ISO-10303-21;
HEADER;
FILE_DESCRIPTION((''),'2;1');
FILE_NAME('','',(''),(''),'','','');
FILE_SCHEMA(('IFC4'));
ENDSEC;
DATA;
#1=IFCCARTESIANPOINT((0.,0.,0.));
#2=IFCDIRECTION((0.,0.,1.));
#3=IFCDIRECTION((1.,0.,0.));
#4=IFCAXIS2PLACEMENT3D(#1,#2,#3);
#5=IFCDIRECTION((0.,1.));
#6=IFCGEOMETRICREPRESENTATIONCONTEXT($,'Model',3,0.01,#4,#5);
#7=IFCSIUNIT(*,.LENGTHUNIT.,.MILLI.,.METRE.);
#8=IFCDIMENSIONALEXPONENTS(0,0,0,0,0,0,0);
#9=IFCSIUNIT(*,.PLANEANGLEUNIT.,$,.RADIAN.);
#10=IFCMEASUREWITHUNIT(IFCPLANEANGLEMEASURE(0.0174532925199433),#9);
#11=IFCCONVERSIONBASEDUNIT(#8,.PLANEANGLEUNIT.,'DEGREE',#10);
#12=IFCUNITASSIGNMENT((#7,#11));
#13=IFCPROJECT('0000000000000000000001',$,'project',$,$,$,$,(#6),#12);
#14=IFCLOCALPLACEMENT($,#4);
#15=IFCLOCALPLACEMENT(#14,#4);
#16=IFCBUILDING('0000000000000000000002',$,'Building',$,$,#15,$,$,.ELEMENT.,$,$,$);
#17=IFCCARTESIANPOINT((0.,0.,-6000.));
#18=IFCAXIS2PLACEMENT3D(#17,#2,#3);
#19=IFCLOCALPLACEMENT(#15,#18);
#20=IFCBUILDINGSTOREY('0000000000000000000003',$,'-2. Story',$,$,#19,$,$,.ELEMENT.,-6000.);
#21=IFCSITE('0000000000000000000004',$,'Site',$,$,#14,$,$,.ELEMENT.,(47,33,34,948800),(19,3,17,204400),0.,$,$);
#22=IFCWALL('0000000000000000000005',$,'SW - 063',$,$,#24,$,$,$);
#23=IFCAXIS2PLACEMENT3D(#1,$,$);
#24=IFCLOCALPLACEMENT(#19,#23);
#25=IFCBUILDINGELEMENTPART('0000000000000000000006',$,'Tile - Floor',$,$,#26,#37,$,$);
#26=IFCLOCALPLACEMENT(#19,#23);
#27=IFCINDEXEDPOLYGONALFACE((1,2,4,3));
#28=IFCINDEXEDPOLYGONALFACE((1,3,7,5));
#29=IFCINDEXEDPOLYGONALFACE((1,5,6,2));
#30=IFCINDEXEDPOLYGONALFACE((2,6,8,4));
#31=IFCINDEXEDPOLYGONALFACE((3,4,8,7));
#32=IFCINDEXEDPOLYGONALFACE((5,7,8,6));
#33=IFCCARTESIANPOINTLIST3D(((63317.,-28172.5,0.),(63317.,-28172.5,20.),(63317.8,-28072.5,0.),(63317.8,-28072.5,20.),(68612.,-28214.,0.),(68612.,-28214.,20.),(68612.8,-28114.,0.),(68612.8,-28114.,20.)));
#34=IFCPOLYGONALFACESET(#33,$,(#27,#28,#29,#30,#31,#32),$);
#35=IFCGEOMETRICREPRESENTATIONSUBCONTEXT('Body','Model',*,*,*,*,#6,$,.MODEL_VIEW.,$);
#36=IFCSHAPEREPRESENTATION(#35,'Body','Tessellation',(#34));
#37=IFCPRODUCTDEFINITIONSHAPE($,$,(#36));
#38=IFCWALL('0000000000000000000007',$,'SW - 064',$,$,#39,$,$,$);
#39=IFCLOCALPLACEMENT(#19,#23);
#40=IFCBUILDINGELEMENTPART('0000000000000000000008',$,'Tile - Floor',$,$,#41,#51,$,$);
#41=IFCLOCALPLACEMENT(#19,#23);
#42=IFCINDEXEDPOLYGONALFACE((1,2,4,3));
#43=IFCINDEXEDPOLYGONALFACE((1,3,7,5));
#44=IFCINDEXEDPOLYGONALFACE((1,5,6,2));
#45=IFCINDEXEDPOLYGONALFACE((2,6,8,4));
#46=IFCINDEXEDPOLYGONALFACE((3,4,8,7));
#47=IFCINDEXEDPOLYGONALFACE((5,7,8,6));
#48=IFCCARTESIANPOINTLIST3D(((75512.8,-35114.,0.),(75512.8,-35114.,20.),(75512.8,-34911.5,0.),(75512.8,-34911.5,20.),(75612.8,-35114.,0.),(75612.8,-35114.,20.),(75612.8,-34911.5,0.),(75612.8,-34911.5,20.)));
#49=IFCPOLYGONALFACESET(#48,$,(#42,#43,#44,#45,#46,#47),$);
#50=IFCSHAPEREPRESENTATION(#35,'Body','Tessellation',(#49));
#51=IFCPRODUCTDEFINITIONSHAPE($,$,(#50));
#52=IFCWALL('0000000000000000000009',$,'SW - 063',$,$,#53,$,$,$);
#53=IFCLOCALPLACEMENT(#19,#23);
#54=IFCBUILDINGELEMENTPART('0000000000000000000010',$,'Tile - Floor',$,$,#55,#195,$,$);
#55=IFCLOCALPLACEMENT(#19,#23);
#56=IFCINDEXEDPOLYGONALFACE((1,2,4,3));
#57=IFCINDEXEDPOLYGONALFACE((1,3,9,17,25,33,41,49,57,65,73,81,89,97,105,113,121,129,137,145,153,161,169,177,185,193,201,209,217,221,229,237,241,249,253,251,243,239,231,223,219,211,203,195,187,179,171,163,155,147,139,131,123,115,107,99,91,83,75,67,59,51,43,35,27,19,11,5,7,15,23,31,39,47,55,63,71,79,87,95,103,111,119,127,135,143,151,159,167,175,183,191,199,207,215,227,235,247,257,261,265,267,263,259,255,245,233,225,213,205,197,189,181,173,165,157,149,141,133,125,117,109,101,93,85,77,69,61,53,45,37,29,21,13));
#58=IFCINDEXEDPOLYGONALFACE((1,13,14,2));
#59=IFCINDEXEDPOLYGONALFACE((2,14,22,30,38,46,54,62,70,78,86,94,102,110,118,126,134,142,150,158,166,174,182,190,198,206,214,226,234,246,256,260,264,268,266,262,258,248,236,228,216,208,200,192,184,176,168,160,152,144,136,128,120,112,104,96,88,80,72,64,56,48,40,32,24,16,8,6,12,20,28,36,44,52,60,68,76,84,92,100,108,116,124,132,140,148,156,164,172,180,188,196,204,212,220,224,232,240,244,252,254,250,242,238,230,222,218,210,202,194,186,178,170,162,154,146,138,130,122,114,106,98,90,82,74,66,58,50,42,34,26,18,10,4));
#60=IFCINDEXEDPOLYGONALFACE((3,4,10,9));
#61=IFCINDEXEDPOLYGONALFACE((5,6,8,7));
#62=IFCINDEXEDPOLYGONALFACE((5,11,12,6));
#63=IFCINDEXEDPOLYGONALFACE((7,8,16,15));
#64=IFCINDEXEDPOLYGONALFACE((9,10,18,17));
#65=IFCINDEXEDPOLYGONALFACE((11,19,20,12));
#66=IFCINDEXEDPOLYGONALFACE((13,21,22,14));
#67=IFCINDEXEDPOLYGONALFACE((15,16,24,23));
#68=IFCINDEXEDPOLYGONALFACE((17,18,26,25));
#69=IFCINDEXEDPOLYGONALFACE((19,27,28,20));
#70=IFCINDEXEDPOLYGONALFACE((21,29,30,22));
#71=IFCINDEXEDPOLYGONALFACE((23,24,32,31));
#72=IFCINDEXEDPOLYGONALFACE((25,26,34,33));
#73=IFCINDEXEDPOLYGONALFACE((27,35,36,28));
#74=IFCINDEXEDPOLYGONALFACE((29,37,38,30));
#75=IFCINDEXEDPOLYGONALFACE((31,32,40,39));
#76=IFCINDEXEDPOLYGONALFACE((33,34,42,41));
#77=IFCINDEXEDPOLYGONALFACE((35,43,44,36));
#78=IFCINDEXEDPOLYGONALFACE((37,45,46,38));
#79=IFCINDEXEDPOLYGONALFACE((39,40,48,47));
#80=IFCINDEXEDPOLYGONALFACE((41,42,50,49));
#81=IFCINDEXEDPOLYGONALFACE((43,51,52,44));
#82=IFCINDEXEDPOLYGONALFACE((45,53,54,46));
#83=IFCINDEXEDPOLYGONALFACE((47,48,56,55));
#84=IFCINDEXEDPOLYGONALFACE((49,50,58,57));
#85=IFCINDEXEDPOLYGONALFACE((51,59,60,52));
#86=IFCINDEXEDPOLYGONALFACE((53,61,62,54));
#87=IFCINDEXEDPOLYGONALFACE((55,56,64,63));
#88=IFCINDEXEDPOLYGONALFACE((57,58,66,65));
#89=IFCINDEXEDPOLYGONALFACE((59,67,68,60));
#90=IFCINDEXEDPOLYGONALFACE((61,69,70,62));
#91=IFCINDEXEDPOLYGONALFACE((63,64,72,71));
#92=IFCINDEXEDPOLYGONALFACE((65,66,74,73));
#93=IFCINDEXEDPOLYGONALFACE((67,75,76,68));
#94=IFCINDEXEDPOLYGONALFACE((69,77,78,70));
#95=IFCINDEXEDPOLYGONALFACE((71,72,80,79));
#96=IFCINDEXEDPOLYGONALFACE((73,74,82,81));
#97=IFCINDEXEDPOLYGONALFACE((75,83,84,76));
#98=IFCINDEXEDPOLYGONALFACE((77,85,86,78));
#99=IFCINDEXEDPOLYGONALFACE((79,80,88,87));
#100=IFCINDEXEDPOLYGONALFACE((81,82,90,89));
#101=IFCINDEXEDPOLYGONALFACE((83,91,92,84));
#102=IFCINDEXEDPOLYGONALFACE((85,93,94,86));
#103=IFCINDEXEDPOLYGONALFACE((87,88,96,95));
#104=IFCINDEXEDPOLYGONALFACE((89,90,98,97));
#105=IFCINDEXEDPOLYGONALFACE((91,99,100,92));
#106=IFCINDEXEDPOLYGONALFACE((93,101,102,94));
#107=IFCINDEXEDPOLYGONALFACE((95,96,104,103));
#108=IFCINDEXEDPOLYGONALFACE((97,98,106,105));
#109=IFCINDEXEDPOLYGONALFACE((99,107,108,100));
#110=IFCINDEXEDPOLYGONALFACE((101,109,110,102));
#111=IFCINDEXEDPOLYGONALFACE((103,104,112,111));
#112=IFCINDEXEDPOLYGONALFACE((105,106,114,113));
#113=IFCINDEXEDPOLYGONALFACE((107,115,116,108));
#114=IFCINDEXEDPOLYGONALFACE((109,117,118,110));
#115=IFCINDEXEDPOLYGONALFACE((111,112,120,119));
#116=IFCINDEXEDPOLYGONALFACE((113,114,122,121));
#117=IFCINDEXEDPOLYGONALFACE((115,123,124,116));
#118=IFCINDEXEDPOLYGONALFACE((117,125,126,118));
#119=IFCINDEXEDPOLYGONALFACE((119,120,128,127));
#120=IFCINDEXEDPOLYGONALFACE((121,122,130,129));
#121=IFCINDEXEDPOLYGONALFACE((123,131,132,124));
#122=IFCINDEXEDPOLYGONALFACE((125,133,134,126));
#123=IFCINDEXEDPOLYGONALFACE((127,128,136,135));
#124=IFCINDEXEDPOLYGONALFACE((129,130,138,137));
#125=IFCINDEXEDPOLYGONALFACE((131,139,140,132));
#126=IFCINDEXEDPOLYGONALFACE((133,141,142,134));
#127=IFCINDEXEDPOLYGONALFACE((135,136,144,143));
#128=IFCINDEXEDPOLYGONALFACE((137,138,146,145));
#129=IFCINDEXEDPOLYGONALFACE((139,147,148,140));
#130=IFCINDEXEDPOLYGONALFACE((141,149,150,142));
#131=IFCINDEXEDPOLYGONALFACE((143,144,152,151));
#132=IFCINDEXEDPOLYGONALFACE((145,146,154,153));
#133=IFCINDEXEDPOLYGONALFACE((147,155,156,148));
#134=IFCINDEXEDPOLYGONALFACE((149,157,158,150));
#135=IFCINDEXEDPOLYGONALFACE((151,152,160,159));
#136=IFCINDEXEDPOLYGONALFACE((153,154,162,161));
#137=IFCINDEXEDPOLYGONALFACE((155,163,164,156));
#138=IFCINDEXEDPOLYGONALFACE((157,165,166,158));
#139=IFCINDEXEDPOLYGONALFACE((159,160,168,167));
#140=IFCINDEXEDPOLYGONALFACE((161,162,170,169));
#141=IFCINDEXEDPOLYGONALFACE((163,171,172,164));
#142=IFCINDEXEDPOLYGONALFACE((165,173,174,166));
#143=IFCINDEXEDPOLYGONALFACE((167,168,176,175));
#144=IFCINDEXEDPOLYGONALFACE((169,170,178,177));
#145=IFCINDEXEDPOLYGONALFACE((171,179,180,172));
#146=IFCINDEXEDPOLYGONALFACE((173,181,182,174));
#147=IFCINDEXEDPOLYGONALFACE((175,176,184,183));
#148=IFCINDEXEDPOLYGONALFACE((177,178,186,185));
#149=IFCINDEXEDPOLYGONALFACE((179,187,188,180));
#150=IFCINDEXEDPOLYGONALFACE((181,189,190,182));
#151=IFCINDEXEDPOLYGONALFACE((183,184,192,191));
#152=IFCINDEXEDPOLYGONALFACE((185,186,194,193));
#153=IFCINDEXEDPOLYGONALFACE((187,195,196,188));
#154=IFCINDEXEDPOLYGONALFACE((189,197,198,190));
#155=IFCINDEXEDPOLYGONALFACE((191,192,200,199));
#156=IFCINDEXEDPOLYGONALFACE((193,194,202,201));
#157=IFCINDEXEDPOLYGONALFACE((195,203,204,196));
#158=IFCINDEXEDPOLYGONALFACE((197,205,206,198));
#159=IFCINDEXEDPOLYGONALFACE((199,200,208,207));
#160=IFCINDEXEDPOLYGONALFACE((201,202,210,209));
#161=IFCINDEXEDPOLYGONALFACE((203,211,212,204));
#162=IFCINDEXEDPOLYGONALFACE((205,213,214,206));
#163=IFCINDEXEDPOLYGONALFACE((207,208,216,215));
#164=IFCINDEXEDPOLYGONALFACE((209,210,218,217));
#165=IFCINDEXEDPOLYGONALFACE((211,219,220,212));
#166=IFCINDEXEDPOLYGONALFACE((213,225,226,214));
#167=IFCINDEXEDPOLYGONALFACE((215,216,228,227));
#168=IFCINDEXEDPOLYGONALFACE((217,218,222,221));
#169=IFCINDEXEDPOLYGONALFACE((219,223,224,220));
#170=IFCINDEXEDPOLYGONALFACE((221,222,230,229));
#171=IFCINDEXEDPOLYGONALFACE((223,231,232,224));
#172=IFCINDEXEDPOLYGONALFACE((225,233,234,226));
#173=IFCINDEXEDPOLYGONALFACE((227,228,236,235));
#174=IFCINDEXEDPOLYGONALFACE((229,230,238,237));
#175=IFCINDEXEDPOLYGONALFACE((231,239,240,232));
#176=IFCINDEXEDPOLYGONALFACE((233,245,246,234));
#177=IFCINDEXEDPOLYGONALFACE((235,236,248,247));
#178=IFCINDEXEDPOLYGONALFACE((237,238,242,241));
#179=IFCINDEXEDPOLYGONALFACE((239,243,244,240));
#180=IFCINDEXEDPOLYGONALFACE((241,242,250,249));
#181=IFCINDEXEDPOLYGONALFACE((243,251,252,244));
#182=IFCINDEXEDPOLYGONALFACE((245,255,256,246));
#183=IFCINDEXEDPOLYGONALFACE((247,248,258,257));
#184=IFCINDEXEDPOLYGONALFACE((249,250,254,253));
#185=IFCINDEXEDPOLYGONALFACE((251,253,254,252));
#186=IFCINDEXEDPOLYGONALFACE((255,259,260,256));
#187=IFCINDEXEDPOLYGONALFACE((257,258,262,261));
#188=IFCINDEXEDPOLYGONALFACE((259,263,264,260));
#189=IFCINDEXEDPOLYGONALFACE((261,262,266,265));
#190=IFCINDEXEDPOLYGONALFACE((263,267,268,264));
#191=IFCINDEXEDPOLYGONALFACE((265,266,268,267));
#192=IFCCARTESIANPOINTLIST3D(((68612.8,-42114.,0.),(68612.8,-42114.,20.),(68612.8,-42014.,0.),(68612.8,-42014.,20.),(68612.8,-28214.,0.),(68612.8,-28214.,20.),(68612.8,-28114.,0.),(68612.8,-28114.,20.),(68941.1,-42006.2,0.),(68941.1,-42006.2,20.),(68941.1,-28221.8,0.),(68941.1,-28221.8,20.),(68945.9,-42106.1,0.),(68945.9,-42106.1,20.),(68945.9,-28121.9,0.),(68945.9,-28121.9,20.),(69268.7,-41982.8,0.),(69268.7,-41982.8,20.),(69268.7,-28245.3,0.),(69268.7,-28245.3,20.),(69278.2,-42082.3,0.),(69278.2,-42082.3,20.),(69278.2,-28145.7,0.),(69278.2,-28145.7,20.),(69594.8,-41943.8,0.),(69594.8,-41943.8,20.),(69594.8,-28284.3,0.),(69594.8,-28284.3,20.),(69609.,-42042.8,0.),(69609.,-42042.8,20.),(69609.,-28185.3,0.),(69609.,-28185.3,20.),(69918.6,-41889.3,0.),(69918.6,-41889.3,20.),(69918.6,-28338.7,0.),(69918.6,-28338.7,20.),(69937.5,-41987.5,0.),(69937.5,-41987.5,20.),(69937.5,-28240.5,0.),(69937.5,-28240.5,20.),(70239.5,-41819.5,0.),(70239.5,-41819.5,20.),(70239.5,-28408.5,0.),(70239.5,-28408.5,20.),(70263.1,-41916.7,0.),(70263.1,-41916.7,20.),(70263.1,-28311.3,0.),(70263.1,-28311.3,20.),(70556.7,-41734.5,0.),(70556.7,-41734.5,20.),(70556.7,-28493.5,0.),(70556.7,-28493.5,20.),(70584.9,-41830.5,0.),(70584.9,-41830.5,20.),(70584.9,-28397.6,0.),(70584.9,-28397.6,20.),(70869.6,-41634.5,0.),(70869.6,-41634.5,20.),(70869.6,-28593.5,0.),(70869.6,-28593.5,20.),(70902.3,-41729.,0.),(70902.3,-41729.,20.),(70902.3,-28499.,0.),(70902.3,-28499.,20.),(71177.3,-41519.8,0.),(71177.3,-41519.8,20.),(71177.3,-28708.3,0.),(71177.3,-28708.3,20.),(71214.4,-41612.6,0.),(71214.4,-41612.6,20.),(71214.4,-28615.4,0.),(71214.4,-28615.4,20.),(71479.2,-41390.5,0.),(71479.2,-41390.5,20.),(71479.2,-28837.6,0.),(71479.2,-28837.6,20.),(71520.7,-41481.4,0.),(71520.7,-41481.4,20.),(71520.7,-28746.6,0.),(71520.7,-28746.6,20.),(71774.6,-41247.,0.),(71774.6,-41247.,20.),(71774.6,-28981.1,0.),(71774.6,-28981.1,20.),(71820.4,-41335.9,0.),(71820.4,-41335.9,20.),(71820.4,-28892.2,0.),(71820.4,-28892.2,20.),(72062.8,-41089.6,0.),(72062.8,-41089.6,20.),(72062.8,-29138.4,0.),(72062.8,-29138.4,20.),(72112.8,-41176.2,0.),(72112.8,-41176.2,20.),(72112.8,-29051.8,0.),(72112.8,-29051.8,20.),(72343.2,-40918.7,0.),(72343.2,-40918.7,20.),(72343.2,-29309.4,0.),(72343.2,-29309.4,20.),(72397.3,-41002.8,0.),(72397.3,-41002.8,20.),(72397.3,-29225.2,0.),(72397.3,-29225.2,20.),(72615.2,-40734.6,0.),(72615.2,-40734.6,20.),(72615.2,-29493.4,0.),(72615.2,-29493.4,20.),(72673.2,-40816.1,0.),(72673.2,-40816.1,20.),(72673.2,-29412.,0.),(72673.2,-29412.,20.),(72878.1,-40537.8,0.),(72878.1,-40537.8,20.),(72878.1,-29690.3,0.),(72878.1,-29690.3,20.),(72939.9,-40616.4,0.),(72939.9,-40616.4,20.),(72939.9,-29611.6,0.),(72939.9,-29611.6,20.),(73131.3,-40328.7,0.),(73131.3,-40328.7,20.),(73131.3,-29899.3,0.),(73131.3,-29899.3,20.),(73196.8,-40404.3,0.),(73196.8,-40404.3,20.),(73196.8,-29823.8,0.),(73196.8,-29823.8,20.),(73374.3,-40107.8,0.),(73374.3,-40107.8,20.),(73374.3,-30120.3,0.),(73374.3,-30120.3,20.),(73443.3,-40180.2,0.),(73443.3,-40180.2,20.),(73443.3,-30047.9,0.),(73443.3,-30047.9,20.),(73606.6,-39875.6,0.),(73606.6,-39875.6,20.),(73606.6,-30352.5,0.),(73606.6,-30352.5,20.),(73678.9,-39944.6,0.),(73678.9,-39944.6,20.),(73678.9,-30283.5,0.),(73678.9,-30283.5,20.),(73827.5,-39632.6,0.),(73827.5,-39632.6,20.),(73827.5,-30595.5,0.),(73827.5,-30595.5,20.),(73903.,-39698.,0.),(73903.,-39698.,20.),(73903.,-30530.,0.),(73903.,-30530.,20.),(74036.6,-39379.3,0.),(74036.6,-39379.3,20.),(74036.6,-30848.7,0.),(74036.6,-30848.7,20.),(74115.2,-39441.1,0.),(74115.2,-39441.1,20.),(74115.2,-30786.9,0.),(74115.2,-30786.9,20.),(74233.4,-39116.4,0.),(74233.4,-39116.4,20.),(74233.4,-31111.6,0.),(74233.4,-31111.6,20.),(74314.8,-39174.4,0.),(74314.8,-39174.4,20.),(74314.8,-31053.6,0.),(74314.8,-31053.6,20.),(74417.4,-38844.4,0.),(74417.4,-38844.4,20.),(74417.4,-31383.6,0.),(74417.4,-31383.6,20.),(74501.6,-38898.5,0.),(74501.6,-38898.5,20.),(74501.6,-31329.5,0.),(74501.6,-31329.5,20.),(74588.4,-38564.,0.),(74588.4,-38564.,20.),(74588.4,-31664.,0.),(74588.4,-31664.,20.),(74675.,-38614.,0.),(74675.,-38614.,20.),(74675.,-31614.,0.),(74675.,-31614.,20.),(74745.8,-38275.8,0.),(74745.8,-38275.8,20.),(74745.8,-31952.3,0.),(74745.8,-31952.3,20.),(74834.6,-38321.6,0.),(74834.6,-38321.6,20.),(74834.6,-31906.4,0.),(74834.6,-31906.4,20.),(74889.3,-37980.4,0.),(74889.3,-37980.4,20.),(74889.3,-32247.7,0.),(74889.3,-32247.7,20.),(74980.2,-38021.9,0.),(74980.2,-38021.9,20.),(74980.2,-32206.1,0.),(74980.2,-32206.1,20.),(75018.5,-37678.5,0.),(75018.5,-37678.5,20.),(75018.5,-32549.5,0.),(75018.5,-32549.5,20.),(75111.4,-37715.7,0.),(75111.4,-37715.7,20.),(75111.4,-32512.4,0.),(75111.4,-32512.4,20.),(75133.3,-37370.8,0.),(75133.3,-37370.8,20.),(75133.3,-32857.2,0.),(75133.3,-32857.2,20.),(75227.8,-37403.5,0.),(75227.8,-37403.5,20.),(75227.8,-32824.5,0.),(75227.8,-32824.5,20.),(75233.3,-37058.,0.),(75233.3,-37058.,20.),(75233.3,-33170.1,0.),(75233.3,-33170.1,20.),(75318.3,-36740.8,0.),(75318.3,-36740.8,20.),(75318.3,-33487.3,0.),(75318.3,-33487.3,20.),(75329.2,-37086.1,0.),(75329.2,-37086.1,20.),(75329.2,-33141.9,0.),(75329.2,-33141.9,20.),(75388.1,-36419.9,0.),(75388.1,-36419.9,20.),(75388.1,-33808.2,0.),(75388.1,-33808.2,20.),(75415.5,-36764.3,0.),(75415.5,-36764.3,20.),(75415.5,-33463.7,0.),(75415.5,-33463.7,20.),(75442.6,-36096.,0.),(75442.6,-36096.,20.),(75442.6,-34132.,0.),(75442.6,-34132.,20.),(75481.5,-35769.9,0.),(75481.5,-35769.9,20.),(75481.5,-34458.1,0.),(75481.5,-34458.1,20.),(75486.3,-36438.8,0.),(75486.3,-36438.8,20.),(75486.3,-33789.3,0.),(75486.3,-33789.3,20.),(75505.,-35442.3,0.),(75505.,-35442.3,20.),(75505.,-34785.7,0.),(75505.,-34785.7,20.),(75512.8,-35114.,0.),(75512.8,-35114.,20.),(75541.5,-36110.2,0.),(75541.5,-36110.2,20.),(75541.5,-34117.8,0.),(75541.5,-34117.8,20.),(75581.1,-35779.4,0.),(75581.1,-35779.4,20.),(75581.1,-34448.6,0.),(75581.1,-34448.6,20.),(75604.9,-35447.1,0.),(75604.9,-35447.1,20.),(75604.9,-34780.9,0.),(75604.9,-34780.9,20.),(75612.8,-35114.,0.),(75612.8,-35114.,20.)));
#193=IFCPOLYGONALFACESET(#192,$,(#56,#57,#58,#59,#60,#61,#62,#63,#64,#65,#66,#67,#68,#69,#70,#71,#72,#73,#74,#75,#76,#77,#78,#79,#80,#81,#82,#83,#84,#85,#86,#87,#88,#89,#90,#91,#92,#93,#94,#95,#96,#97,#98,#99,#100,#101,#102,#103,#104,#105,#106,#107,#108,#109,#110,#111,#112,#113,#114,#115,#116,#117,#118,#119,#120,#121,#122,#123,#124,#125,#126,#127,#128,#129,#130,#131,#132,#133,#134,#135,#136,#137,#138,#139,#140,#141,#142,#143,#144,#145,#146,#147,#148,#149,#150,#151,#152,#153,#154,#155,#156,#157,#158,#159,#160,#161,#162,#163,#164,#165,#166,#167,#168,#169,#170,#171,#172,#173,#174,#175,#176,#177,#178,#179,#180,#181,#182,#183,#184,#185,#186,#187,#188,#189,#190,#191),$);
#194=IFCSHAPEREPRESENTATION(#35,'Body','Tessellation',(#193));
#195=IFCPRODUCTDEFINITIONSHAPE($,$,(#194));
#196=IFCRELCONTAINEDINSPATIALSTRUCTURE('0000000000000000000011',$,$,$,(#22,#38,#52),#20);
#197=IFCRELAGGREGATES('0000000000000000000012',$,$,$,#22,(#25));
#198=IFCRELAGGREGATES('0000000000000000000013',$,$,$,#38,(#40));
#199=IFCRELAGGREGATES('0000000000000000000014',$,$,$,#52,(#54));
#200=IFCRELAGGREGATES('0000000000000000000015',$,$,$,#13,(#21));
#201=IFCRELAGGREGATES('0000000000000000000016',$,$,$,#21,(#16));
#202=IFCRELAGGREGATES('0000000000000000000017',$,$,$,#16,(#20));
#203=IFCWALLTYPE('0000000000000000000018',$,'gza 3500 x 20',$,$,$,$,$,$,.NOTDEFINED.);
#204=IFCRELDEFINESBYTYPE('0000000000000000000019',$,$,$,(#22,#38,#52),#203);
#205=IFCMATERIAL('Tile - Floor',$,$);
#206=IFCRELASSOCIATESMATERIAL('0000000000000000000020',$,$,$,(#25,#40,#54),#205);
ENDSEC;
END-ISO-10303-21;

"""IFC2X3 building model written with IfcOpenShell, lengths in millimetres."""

from ifc_helpers import new_model, entity, si_unit, converted_unit, direction, frame, origin_with_axes, place, context, subcontext, project, spatial, polyline, outline, extrude, material, type_object, element, aggregate, save


model = new_model("IFC2X3")

# Units and contexts
model_context = context("Model", 3, precision=0.01, world=origin_with_axes(), true_north=direction((0.0, 1.0)))
body_context = subcontext(model_context, "Body", "Model", "MODEL_VIEW")
ifc_project = project(units=[si_unit("LENGTHUNIT", "METRE", prefix="MILLI"), converted_unit("PLANEANGLEUNIT", "DEGREE", entity("IfcPlaneAngleMeasure", 0.0174532925199433), si_unit("PLANEANGLEUNIT", "RADIAN"), dimensions=[0, 0, 0, 0, 0, 0, 0])], contexts=[model_context])

# Site, building, storey
site_placement = place(None, origin_with_axes())
site = spatial("IfcSite", under=ifc_project, at=site_placement, Name="Site", CompositionType="ELEMENT", RefLatitude=(47, 33, 34, 948800), RefLongitude=(19, 3, 17, 204400), RefElevation=0.0)
building_placement = place(site_placement, origin_with_axes())
building = spatial("IfcBuilding", under=site, at=building_placement, Name="Building", CompositionType="ELEMENT")
storey_placement = place(building_placement, frame((0.0, 0.0, -6000.0), z_axis=(0.0, 0.0, 1.0), x_axis=(1.0, 0.0, 0.0)))
storey = spatial("IfcBuildingStorey", under=building, at=storey_placement, Name="-2. Story", CompositionType="ELEMENT", Elevation=-6000.0)

# Walls, building element parts
wall_type_1 = type_object("IfcWallType", Name="gza 3500 x 20", PredefinedType="NOTDEFINED")
wall_1_placement = place(storey_placement, frame((63317.8, -28072.5, 0.0), z_axis=(0.0, 0.0, 1.0), x_axis=(0.999969, -0.007836, 0.0)))
wall_1 = element("IfcWall", 1, at=wall_1_placement, inside=storey, type_object=wall_type_1, Name="SW - 063")
ifc_material_1 = material(Name="Tile - Floor")
building_element_part_1_placement = place(wall_1_placement, origin_with_axes())
building_element_part_1 = element("IfcBuildingElementPart", 2, at=building_element_part_1_placement, material=ifc_material_1, Name="Tile - Floor", context=body_context, shape_type="SweptSolid", body=[
    extrude(outline(polyline([(100.0, 0.0), (100.0, 20.0), (0.0, 20.0), (0.0, 0.0), (100.0, 0.0)])), frame((0.0, 0.0, 0.0), z_axis=(-1.0, 0.0, 0.0), x_axis=(0.0, -1.0, 0.0)), (0.0, 0.0, -1.0), 5295.2),
])
aggregate(wall_1, [building_element_part_1])
wall_2_placement = place(storey_placement, frame((75612.8, -34911.5, 0.0), z_axis=(0.0, 0.0, 1.0), x_axis=(0.0, -1.0, 0.0)))
wall_2 = element("IfcWall", 3, at=wall_2_placement, inside=storey, type_object=wall_type_1, Name="SW - 064")
building_element_part_2_placement = place(wall_2_placement, origin_with_axes())
building_element_part_2 = element("IfcBuildingElementPart", 4, at=building_element_part_2_placement, material=ifc_material_1, Name="Tile - Floor", context=body_context, shape_type="SweptSolid", body=[
    extrude(outline(polyline([(100.0, 0.0), (100.0, 20.0), (0.0, 20.0), (0.0, 0.0), (100.0, 0.0)])), frame((0.0, 0.0, 0.0), z_axis=(-1.0, 0.0, 0.0), x_axis=(0.0, -1.0, 0.0)), (0.0, 0.0, -1.0), 202.5),
])
aggregate(wall_2, [building_element_part_2])
wall_3_placement = place(storey_placement, frame((68612.8, -42114.0, 0.0), z_axis=(0.0, 0.0, 1.0), x_axis=(1.0, 0.0, 0.0)))
wall_3 = element("IfcWall", 5, at=wall_3_placement, inside=storey, type_object=wall_type_1, Name="SW - 063")
building_element_part_3_placement = place(wall_3_placement, origin_with_axes())
cartesian_point_1 = entity("IfcCartesianPoint", [100.0, 0.0])
building_element_part_3 = element("IfcBuildingElementPart", 6, at=building_element_part_3_placement, material=ifc_material_1, Name="Tile - Floor", context=body_context, shape_type="SweptSolid", body=[
    entity("IfcRevolvedAreaSolid", entity("IfcArbitraryClosedProfileDef", "AREA", None, entity("IfcPolyline", [cartesian_point_1, entity("IfcCartesianPoint", [100.0, 20.0]), entity("IfcCartesianPoint", [0.0, 20.0]), entity("IfcCartesianPoint", [0.0, 0.0]), cartesian_point_1])), entity("IfcAxis2Placement3D", entity("IfcCartesianPoint", [0.0, 0.0, 0.0]), entity("IfcDirection", [1.0, 0.0, 0.0]), entity("IfcDirection", [0.0, 1.0, 0.0])), entity("IfcAxis1Placement", entity("IfcCartesianPoint", [7000.0, 0.0, 0.0]), entity("IfcDirection", [0.0, 1.0, 0.0])), 180.0),
])
aggregate(wall_3, [building_element_part_3])

save(model, "model.ifc")
